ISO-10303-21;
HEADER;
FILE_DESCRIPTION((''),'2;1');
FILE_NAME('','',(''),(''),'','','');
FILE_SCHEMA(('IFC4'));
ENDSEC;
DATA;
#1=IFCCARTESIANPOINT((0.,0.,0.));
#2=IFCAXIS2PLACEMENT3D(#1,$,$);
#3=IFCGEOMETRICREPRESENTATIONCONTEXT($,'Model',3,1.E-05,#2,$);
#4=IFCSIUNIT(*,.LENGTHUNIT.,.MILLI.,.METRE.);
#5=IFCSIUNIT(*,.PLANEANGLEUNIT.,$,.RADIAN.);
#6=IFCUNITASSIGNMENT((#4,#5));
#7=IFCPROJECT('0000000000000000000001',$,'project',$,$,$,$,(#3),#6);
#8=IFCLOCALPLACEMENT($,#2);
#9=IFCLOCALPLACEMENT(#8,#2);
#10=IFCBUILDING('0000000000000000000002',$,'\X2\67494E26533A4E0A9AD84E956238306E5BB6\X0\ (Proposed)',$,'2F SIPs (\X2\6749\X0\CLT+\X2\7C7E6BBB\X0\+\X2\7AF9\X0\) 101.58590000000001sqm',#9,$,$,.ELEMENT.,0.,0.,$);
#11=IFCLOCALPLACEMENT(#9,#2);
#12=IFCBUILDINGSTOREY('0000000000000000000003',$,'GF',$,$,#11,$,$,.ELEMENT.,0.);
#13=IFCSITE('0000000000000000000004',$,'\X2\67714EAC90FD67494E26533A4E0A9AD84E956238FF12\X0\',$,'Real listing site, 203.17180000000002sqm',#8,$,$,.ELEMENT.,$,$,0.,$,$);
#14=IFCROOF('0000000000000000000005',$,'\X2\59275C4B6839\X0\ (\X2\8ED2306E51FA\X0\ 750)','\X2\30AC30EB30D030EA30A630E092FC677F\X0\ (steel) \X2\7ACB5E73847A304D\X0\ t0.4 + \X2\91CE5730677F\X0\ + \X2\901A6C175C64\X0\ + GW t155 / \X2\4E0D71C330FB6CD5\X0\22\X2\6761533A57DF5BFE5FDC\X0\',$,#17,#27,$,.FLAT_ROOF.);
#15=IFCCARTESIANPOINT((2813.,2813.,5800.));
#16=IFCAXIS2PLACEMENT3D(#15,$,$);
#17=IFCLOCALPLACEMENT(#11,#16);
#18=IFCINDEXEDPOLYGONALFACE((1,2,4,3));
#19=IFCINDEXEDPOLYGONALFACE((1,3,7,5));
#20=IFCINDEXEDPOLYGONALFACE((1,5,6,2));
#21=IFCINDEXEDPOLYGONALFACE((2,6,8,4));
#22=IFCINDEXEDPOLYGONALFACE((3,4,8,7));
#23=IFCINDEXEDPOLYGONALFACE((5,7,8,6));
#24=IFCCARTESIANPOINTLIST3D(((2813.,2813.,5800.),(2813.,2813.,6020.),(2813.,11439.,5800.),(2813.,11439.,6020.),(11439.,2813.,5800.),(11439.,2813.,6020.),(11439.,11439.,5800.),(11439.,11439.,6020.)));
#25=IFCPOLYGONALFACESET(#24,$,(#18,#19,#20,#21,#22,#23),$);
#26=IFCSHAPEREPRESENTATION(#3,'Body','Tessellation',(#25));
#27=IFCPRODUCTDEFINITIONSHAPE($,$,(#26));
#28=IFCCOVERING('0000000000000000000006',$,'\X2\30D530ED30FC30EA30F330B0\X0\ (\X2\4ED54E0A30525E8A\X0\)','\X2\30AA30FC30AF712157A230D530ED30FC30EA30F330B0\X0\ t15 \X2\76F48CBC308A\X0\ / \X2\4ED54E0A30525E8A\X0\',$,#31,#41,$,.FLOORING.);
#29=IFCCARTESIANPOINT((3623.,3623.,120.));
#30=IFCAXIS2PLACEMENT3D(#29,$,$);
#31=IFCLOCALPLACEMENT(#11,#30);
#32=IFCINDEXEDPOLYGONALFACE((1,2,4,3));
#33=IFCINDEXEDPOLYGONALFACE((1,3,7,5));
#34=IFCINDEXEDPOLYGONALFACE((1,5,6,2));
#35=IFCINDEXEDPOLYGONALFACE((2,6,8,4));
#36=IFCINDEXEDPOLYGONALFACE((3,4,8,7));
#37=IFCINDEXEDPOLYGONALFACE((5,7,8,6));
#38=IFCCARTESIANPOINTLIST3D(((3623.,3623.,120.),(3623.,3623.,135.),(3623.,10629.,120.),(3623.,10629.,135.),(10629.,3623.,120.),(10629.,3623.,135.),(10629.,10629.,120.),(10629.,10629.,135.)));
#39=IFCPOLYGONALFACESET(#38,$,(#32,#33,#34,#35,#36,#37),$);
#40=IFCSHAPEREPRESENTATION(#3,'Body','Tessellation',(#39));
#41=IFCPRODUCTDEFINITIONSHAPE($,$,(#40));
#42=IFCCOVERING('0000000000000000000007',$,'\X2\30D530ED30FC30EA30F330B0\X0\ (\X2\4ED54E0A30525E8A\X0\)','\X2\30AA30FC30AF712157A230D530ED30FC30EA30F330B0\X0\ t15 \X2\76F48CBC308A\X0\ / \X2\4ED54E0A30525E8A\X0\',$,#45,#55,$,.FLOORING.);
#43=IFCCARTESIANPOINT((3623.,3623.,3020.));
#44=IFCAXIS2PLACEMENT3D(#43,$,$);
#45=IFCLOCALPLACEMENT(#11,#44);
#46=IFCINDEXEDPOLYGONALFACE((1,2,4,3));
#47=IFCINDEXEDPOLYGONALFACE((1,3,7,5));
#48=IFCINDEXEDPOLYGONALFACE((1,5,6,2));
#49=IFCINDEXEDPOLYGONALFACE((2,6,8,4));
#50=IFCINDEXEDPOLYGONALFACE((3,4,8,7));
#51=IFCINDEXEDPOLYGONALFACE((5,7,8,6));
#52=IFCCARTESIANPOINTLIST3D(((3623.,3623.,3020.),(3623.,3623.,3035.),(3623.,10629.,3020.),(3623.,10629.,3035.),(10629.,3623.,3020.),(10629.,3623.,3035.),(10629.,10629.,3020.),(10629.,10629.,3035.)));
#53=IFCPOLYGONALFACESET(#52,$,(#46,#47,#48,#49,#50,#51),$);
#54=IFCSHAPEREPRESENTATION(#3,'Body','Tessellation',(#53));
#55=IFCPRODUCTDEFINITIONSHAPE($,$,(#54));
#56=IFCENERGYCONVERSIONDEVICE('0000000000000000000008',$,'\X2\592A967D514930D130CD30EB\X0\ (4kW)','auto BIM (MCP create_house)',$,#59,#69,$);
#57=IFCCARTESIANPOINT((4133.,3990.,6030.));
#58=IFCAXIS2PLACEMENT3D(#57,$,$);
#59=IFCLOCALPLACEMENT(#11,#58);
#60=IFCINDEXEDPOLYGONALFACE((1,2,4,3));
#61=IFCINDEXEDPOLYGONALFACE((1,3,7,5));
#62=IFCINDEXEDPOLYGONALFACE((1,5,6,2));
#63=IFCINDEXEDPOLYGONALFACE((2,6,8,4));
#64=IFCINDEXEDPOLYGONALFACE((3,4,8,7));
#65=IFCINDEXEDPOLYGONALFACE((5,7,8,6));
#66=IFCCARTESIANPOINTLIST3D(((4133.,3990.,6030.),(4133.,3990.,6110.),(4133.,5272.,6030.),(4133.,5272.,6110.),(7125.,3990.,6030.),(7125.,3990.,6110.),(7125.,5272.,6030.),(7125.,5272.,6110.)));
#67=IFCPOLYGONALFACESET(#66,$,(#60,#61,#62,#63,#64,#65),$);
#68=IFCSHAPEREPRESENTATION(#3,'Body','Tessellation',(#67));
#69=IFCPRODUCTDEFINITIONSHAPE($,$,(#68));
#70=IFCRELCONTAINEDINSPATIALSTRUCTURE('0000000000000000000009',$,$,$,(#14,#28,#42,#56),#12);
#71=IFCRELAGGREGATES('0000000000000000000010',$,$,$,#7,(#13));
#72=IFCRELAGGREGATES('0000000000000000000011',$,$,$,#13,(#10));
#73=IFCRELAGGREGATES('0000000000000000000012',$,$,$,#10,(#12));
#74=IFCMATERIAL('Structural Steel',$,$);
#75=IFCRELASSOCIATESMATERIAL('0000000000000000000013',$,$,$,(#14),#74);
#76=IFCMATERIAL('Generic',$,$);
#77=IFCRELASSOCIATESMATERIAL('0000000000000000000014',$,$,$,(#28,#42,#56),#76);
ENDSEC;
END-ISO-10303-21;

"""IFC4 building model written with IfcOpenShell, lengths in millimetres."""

from ifc_helpers import new_model, si_unit, frame, frame_2d, origin, place, context, project, spatial, rectangle, extrude, material, element, save


model = new_model("IFC4")

# Units and contexts
model_context = context("Model", 3, precision=1e-05, world=origin())
ifc_project = project(units=[si_unit("LENGTHUNIT", "METRE", prefix="MILLI"), si_unit("PLANEANGLEUNIT", "RADIAN")], contexts=[model_context])

# Site, building, storey
site_placement = place(None, origin())
site = spatial("IfcSite", under=ifc_project, at=site_placement, Name="東京都杉並区上高井戸２", ObjectType="Real listing site, 203.17180000000002sqm", CompositionType="ELEMENT", RefElevation=0.0)
building_placement = place(site_placement, origin())
building = spatial("IfcBuilding", under=site, at=building_placement, Name="杉並区上高井戸の家 (Proposed)", ObjectType="2F SIPs (杉CLT+籾殻+竹) 101.58590000000001sqm", CompositionType="ELEMENT", ElevationOfRefHeight=0.0, ElevationOfTerrain=0.0)
storey_placement = place(building_placement, origin())
storey = spatial("IfcBuildingStorey", under=building, at=storey_placement, Name="GF", CompositionType="ELEMENT", Elevation=0.0)

# Roof
ifc_material_1 = material(Name="Structural Steel")
roof_placement = place(storey_placement, frame((2813.0, 2813.0, 5800.0)))
element("IfcRoof", 1, at=roof_placement, inside=storey, material=ifc_material_1, Name="大屋根 (軒の出 750)", Description="ガルバリウム鋼板 (steel) 立平葺き t0.4 + 野地板 + 通気層 + GW t155 / 不燃・法22条区域対応", PredefinedType="FLAT_ROOF", context=model_context, shape_type="SweptSolid", body=[
    extrude(rectangle(XDim=8626.0, YDim=8626.0, at=frame_2d((4313.0, 4313.0))), frame((2813.0, 2813.0, 5800.0)), (0.0, 0.0, 1.0), 220.0),
])

# Coverings
ifc_material_2 = material(Name="Generic")
covering_1_placement = place(storey_placement, frame((3623.0, 3623.0, 120.0)))
element("IfcCovering", 2, at=covering_1_placement, inside=storey, material=ifc_material_2, Name="フローリング (仕上げ床)", Description="オーク無垢フローリング t15 直貼り / 仕上げ床", PredefinedType="FLOORING", context=model_context, shape_type="SweptSolid", body=[
    extrude(rectangle(XDim=7006.0, YDim=7006.0, at=frame_2d((3503.0, 3503.0))), frame((3623.0, 3623.0, 120.0)), (0.0, 0.0, 1.0), 15.0),
])
covering_2_placement = place(storey_placement, frame((3623.0, 3623.0, 3020.0)))
element("IfcCovering", 3, at=covering_2_placement, inside=storey, material=ifc_material_2, Name="フローリング (仕上げ床)", Description="オーク無垢フローリング t15 直貼り / 仕上げ床", PredefinedType="FLOORING", context=model_context, shape_type="SweptSolid", body=[
    extrude(rectangle(XDim=7006.0, YDim=7006.0, at=frame_2d((3503.0, 3503.0))), frame((3623.0, 3623.0, 3020.0)), (0.0, 0.0, 1.0), 15.0),
])

# Energy conversion device
energy_conversion_device_placement = place(storey_placement, frame((4133.0, 3990.0, 6030.0)))
element("IfcEnergyConversionDevice", 4, at=energy_conversion_device_placement, inside=storey, material=ifc_material_2, Name="太陽光パネル (4kW)", Description="auto BIM (MCP create_house)", context=model_context, shape_type="SweptSolid", body=[
    extrude(rectangle(XDim=2992.0, YDim=1282.0, at=frame_2d((1496.0, 641.0))), frame((4133.0, 3990.0, 6030.0)), (0.0, 0.0, 1.0), 80.0),
])

save(model, "model.ifc")
